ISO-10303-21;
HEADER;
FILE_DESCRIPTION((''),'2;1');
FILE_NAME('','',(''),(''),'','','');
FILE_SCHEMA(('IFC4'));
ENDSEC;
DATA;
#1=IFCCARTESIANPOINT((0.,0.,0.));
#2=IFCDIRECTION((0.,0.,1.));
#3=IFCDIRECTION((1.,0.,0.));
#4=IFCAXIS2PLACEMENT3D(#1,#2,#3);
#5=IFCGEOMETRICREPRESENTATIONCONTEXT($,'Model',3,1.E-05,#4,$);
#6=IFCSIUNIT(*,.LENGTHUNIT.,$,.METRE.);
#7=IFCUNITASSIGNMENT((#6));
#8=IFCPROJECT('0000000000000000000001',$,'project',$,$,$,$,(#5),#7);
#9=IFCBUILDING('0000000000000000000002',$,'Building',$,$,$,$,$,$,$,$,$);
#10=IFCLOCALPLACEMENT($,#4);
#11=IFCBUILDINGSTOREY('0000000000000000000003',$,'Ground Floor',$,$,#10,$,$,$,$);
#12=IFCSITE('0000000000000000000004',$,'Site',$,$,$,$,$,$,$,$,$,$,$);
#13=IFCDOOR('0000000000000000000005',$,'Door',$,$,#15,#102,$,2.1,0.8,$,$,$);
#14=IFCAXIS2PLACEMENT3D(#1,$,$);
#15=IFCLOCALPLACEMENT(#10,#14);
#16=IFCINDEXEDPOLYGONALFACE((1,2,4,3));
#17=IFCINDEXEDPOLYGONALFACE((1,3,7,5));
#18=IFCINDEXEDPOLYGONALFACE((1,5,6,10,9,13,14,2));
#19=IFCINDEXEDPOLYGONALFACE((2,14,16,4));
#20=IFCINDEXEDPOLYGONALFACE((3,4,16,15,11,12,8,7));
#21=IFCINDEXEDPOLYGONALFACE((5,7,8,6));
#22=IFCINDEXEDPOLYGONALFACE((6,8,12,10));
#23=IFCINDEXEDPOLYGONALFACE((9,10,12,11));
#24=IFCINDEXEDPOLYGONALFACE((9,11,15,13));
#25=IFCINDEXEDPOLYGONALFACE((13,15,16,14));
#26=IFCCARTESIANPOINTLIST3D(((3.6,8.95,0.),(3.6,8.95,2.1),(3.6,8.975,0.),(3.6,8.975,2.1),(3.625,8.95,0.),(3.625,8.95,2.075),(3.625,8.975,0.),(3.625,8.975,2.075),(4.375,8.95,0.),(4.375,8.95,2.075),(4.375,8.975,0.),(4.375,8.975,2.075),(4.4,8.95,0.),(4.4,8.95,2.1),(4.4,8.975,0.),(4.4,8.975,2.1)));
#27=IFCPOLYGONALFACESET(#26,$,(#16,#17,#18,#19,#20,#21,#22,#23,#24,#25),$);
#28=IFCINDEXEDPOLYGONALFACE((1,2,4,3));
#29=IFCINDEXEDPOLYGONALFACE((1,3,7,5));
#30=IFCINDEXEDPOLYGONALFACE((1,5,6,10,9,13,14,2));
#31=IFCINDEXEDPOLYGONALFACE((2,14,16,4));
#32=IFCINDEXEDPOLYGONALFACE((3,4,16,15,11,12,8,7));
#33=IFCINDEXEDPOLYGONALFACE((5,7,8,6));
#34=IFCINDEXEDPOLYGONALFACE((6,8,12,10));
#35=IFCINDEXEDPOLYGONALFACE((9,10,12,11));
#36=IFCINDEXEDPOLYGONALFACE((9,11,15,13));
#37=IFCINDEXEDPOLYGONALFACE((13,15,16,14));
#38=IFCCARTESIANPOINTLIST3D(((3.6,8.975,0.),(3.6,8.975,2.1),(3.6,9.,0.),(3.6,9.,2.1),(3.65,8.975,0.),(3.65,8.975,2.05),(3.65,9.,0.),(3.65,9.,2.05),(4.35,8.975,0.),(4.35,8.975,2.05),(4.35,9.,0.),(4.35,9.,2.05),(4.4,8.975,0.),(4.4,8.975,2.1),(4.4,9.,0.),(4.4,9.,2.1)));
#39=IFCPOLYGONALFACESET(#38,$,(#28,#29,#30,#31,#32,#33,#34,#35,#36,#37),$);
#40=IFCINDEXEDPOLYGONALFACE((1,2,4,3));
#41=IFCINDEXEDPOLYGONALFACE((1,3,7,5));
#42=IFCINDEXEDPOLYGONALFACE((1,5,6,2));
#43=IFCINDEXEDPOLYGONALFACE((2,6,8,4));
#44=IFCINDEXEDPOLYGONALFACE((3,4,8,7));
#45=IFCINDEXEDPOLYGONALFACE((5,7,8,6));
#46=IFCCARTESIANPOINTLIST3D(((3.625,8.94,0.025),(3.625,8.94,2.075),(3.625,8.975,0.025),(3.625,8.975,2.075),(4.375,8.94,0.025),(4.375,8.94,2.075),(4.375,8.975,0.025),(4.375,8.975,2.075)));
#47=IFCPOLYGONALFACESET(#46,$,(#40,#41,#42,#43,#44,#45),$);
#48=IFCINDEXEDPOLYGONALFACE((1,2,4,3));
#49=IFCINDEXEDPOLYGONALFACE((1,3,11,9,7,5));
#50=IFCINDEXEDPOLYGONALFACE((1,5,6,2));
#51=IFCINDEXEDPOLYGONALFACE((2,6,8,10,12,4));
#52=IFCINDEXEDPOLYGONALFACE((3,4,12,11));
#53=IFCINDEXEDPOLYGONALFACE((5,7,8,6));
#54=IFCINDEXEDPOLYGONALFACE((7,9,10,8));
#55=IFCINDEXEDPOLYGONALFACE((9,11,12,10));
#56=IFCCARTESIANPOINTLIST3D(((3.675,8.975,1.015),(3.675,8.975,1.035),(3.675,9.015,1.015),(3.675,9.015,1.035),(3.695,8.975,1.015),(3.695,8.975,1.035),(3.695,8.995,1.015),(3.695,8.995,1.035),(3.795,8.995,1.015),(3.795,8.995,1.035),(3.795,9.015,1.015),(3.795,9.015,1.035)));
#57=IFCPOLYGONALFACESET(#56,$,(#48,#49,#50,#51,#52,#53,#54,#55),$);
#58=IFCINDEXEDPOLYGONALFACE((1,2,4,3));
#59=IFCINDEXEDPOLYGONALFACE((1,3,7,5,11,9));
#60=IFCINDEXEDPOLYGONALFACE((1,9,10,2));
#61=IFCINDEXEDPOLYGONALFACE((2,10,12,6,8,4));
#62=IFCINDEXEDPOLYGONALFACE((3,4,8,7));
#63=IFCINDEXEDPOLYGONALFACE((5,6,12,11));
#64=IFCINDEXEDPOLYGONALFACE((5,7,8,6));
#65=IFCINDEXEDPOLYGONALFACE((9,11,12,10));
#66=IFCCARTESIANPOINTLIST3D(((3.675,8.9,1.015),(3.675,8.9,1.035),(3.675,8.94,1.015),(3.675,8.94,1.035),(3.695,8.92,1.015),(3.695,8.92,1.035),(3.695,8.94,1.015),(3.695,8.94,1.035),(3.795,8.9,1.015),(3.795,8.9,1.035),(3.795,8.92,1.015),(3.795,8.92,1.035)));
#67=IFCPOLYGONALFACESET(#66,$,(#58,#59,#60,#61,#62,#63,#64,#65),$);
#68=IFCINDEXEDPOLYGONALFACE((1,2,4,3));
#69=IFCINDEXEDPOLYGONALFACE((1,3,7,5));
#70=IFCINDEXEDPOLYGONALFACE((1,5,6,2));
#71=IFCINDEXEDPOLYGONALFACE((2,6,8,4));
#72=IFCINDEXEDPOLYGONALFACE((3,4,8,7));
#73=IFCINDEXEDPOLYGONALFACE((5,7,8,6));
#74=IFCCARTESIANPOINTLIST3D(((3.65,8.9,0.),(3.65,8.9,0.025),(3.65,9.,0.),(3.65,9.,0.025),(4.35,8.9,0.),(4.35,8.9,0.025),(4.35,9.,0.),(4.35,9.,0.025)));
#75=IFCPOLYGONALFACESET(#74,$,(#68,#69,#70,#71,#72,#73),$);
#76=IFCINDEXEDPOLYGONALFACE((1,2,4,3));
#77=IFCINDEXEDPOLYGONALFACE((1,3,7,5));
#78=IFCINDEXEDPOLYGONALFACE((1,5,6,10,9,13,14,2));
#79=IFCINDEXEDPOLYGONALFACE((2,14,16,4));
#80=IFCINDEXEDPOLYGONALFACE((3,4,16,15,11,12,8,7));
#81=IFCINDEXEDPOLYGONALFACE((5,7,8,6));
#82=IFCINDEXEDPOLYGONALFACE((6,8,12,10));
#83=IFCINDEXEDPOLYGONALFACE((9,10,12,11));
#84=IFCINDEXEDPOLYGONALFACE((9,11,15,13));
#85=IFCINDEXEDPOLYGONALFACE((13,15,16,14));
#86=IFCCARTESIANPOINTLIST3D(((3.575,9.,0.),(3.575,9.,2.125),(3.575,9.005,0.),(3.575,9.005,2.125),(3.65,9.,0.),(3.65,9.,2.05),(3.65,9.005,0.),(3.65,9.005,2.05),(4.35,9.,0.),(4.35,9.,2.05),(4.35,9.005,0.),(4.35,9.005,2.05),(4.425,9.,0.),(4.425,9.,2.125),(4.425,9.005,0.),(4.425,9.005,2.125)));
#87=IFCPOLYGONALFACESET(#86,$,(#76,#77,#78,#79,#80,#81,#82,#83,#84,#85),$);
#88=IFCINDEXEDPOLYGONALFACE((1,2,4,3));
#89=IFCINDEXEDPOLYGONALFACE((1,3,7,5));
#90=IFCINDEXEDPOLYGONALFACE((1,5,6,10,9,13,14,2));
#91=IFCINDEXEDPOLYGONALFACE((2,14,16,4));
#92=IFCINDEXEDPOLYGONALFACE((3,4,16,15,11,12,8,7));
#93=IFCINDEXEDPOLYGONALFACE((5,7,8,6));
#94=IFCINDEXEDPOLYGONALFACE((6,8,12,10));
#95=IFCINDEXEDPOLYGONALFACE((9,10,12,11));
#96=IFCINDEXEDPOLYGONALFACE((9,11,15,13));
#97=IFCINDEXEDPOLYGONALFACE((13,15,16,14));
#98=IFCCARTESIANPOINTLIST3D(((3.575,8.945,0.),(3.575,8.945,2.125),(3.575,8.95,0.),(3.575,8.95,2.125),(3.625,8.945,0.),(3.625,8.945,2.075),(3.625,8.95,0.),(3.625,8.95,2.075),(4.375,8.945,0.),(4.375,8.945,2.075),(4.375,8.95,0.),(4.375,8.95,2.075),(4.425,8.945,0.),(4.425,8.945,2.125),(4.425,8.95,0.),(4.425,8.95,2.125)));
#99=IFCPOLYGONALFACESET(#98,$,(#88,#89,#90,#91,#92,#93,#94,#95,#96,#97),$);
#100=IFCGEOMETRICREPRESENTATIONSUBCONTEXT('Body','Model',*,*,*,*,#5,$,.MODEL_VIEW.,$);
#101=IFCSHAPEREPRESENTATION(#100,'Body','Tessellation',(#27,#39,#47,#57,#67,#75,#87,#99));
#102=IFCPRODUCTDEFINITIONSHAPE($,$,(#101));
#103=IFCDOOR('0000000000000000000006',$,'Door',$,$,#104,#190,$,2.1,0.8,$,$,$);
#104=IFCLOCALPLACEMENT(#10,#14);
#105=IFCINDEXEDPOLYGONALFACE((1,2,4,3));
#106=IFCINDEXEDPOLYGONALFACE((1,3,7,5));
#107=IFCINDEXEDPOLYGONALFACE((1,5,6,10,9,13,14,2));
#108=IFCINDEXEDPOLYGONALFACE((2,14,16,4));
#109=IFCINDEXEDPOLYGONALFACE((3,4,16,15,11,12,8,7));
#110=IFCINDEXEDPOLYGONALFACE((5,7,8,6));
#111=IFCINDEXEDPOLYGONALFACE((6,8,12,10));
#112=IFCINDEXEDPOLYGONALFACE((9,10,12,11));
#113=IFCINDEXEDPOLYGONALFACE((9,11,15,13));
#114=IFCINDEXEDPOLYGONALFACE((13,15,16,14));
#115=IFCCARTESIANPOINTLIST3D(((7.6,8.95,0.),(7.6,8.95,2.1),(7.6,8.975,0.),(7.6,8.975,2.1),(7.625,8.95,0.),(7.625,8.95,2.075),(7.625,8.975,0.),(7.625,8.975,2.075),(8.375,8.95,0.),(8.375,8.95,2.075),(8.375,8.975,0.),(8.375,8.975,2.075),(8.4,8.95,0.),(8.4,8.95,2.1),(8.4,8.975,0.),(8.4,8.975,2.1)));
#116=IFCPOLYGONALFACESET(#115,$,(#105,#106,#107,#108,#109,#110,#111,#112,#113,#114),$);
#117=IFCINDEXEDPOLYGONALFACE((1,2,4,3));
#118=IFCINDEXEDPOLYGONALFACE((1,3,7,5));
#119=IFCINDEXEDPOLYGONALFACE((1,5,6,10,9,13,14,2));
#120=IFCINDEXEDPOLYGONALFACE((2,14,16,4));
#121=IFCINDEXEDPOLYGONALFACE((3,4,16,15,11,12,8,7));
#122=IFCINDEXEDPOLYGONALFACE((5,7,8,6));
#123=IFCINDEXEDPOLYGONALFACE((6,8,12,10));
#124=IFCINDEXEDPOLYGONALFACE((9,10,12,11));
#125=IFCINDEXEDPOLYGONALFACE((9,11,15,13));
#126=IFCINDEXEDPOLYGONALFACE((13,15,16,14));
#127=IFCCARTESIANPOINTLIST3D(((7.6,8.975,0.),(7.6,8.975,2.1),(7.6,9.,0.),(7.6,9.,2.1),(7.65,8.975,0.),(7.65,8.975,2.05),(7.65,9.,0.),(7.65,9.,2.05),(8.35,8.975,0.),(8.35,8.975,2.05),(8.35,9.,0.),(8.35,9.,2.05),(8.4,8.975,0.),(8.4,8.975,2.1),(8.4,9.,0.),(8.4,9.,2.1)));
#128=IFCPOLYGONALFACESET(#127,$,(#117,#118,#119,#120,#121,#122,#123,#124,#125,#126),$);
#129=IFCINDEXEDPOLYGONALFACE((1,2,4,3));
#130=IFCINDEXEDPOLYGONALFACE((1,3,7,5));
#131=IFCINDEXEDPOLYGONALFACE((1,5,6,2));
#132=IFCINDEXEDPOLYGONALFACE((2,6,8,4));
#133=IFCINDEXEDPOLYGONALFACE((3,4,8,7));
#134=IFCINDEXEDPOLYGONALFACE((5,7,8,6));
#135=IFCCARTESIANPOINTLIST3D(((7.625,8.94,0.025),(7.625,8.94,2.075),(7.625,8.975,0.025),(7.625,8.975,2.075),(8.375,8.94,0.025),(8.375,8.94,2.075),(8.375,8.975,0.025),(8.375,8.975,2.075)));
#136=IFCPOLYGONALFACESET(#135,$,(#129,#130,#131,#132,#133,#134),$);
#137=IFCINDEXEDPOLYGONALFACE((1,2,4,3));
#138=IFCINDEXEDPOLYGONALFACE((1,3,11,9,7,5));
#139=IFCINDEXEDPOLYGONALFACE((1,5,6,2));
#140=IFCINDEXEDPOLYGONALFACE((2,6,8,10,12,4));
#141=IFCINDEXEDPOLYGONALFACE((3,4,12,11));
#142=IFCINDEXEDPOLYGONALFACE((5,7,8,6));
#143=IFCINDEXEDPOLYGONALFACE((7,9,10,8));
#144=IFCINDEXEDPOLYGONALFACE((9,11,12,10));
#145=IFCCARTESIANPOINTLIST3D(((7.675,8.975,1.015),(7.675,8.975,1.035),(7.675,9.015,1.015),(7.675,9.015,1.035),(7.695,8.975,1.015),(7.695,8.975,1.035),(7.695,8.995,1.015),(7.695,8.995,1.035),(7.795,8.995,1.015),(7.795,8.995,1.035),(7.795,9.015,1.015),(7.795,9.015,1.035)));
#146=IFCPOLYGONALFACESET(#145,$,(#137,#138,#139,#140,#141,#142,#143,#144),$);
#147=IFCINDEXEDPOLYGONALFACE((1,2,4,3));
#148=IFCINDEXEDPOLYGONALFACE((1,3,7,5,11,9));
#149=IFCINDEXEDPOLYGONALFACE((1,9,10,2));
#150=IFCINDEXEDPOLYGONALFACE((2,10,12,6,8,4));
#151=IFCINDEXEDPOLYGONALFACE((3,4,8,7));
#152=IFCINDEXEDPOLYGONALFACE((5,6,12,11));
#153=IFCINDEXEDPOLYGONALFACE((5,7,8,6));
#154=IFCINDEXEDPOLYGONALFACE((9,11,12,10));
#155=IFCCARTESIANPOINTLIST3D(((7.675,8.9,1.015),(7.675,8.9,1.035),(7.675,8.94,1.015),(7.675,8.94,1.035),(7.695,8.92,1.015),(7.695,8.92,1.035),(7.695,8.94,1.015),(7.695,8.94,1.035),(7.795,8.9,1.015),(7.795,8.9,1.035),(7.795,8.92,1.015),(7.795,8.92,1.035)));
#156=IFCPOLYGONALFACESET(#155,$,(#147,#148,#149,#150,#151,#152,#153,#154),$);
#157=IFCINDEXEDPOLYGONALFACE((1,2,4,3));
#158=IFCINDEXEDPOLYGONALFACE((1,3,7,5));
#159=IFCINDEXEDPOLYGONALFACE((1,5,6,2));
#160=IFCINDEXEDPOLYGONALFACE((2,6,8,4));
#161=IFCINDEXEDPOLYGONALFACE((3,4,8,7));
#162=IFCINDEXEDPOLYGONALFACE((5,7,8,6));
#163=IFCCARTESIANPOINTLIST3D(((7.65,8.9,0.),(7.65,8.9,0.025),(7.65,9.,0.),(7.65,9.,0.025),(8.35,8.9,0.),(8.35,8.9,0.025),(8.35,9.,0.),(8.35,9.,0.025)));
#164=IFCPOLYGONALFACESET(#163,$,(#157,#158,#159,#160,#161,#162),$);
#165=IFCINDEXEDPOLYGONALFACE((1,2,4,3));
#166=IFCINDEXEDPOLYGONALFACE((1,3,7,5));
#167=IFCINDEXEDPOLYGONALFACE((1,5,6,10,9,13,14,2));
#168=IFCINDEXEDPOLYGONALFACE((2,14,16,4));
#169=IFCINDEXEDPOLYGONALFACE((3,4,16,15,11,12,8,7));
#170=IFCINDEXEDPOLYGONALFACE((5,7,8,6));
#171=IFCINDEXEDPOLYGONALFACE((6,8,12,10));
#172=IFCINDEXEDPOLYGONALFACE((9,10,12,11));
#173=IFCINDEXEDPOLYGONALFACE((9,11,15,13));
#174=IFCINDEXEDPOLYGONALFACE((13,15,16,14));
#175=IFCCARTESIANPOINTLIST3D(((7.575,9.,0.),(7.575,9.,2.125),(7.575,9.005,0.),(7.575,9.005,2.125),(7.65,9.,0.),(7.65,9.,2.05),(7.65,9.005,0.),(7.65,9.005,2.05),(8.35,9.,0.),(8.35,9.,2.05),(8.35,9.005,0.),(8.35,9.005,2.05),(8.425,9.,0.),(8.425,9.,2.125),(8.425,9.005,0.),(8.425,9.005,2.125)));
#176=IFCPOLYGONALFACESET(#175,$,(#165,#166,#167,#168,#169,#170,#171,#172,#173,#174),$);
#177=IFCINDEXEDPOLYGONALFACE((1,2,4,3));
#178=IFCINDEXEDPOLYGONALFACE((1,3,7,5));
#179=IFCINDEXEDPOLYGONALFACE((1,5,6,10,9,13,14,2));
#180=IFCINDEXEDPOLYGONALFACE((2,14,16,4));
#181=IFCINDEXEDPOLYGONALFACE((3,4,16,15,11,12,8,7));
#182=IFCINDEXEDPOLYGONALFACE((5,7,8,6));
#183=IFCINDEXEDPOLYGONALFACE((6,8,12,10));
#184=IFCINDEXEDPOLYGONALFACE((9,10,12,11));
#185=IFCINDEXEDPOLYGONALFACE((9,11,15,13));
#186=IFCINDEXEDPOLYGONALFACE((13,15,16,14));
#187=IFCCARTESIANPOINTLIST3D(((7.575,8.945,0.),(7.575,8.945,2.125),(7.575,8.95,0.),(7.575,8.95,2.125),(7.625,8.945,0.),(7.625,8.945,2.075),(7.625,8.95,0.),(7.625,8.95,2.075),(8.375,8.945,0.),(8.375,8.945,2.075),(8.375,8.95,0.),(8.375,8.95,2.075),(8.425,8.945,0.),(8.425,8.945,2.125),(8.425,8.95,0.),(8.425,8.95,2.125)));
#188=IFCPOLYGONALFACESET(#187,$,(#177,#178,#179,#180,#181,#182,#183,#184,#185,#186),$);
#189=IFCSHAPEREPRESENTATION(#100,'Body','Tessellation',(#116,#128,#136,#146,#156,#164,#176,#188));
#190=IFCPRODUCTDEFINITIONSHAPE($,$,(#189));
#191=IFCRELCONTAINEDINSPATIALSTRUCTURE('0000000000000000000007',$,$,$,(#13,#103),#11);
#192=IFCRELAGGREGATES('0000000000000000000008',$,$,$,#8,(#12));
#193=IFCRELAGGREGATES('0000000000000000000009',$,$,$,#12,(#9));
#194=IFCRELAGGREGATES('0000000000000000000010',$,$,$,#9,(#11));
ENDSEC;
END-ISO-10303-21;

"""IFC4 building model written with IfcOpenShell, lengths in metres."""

from ifc_helpers import new_model, si_unit, frame, origin_with_axes, place, context, subcontext, project, spatial, line, indexed_curve, outline, extrude, element, save


model = new_model("IFC4")

# Units and contexts
model_context = context("Model", 3, precision=1e-05, world=origin_with_axes())
body_context = subcontext(model_context, "Body", "Model", "MODEL_VIEW")
ifc_project = project(units=[si_unit("LENGTHUNIT", "METRE")], contexts=[model_context])

# Site, building, storey
site = spatial("IfcSite", under=ifc_project, Name="Site")
building = spatial("IfcBuilding", under=site, Name="Building")
storey_placement = place(None, origin_with_axes())
storey = spatial("IfcBuildingStorey", under=building, at=storey_placement, Name="Ground Floor")

# Doors
door_1_placement = place(storey_placement, frame((4.4, 9.0, 0.0), z_axis=(0.0, 0.0, 1.0), x_axis=(-1.0, 0.0, 0.0)))
element("IfcDoor", 1, at=door_1_placement, inside=storey, Name="Door", OverallHeight=2.1, OverallWidth=0.8, context=body_context, shape_type="SweptSolid", body=[
    extrude(outline(indexed_curve([(0.0, 0.0), (0.0, 2.1), (0.8, 2.1), (0.8, 0.0), (0.775, 0.0), (0.775, 2.075), (0.025, 2.075), (0.025, 0.0)], segments=[line(1, 2, 3, 4, 5, 6, 7, 8, 1)])), frame((0.0, 0.025, 0.0), z_axis=(0.0, -1.0, 0.0), x_axis=(1.0, 0.0, 0.0)), (0.0, 0.0, -1.0), 0.025),
    extrude(outline(indexed_curve([(0.0, 0.0), (0.0, 2.1), (0.8, 2.1), (0.8, 0.0), (0.75, 0.0), (0.75, 2.05), (0.05, 2.05), (0.05, 0.0)], segments=[line(1, 2, 3, 4, 5, 6, 7, 8, 1)])), frame((0.0, 0.0, 0.0), z_axis=(0.0, -1.0, 0.0), x_axis=(1.0, 0.0, 0.0)), (0.0, 0.0, -1.0), 0.025),
    extrude(outline(indexed_curve([(0.0, 0.0), (0.75, 0.0), (0.75, 0.035), (0.0, 0.035)], segments=[line(1, 2, 3, 4, 1)])), frame((0.025, 0.025, 0.025), z_axis=(0.0, 0.0, 1.0), x_axis=(1.0, 0.0, 0.0)), (0.0, 0.0, 1.0), 2.05),
    extrude(outline(indexed_curve([(0.0, 0.0), (0.0, -0.04), (-0.12, -0.04), (-0.12, -0.02), (-0.02, -0.02), (-0.02, 0.0)], segments=[line(1, 2, 3, 4, 5, 6, 1)])), frame((0.725, 0.025, 1.015), z_axis=(0.0, 0.0, 1.0), x_axis=(1.0, 0.0, 0.0)), (0.0, 0.0, 1.0), 0.02),
    extrude(outline(indexed_curve([(0.0, 0.0), (0.0, 0.04), (-0.12, 0.04), (-0.12, 0.02), (-0.02, 0.02), (-0.02, 0.0)], segments=[line(1, 2, 3, 4, 5, 6, 1)])), frame((0.725, 0.06, 1.015), z_axis=(0.0, 0.0, 1.0), x_axis=(1.0, 0.0, 0.0)), (0.0, 0.0, 1.0), 0.02),
    extrude(outline(indexed_curve([(0.0, 0.0), (0.7, 0.0), (0.7, 0.1), (0.0, 0.1)], segments=[line(1, 2, 3, 4, 1)])), frame((0.05, 0.0, 0.0), z_axis=(0.0, 0.0, 1.0), x_axis=(1.0, 0.0, 0.0)), (0.0, 0.0, 1.0), 0.025),
    extrude(outline(indexed_curve([(0.0, 0.0), (0.0, 2.125), (0.85, 2.125), (0.85, 0.0), (0.775, 0.0), (0.775, 2.05), (0.075, 2.05), (0.075, 0.0)], segments=[line(1, 2, 3, 4, 5, 6, 7, 8, 1)])), frame((-0.025, -0.005, 0.0), z_axis=(0.0, -1.0, 0.0), x_axis=(1.0, 0.0, 0.0)), (0.0, 0.0, -1.0), 0.005),
    extrude(outline(indexed_curve([(0.0, 0.0), (0.0, 2.125), (0.85, 2.125), (0.85, 0.0), (0.8, 0.0), (0.8, 2.075), (0.05, 2.075), (0.05, 0.0)], segments=[line(1, 2, 3, 4, 5, 6, 7, 8, 1)])), frame((-0.025, 0.05, 0.0), z_axis=(0.0, -1.0, 0.0), x_axis=(1.0, 0.0, 0.0)), (0.0, 0.0, -1.0), 0.005),
])
door_2_placement = place(storey_placement, frame((8.4, 9.0, 0.0), z_axis=(0.0, 0.0, 1.0), x_axis=(-1.0, 0.0, 0.0)))
element("IfcDoor", 2, at=door_2_placement, inside=storey, Name="Door", OverallHeight=2.1, OverallWidth=0.8, context=body_context, shape_type="SweptSolid", body=[
    extrude(outline(indexed_curve([(0.0, 0.0), (0.0, 2.1), (0.8, 2.1), (0.8, 0.0), (0.775, 0.0), (0.775, 2.075), (0.025, 2.075), (0.025, 0.0)], segments=[line(1, 2, 3, 4, 5, 6, 7, 8, 1)])), frame((0.0, 0.025, 0.0), z_axis=(0.0, -1.0, 0.0), x_axis=(1.0, 0.0, 0.0)), (0.0, 0.0, -1.0), 0.025),
    extrude(outline(indexed_curve([(0.0, 0.0), (0.0, 2.1), (0.8, 2.1), (0.8, 0.0), (0.75, 0.0), (0.75, 2.05), (0.05, 2.05), (0.05, 0.0)], segments=[line(1, 2, 3, 4, 5, 6, 7, 8, 1)])), frame((0.0, 0.0, 0.0), z_axis=(0.0, -1.0, 0.0), x_axis=(1.0, 0.0, 0.0)), (0.0, 0.0, -1.0), 0.025),
    extrude(outline(indexed_curve([(0.0, 0.0), (0.75, 0.0), (0.75, 0.035), (0.0, 0.035)], segments=[line(1, 2, 3, 4, 1)])), frame((0.025, 0.025, 0.025), z_axis=(0.0, 0.0, 1.0), x_axis=(1.0, 0.0, 0.0)), (0.0, 0.0, 1.0), 2.05),
    extrude(outline(indexed_curve([(0.0, 0.0), (0.0, -0.04), (-0.12, -0.04), (-0.12, -0.02), (-0.02, -0.02), (-0.02, 0.0)], segments=[line(1, 2, 3, 4, 5, 6, 1)])), frame((0.725, 0.025, 1.015), z_axis=(0.0, 0.0, 1.0), x_axis=(1.0, 0.0, 0.0)), (0.0, 0.0, 1.0), 0.02),
    extrude(outline(indexed_curve([(0.0, 0.0), (0.0, 0.04), (-0.12, 0.04), (-0.12, 0.02), (-0.02, 0.02), (-0.02, 0.0)], segments=[line(1, 2, 3, 4, 5, 6, 1)])), frame((0.725, 0.06, 1.015), z_axis=(0.0, 0.0, 1.0), x_axis=(1.0, 0.0, 0.0)), (0.0, 0.0, 1.0), 0.02),
    extrude(outline(indexed_curve([(0.0, 0.0), (0.7, 0.0), (0.7, 0.1), (0.0, 0.1)], segments=[line(1, 2, 3, 4, 1)])), frame((0.05, 0.0, 0.0), z_axis=(0.0, 0.0, 1.0), x_axis=(1.0, 0.0, 0.0)), (0.0, 0.0, 1.0), 0.025),
    extrude(outline(indexed_curve([(0.0, 0.0), (0.0, 2.125), (0.85, 2.125), (0.85, 0.0), (0.775, 0.0), (0.775, 2.05), (0.075, 2.05), (0.075, 0.0)], segments=[line(1, 2, 3, 4, 5, 6, 7, 8, 1)])), frame((-0.025, -0.005, 0.0), z_axis=(0.0, -1.0, 0.0), x_axis=(1.0, 0.0, 0.0)), (0.0, 0.0, -1.0), 0.005),
    extrude(outline(indexed_curve([(0.0, 0.0), (0.0, 2.125), (0.85, 2.125), (0.85, 0.0), (0.8, 0.0), (0.8, 2.075), (0.05, 2.075), (0.05, 0.0)], segments=[line(1, 2, 3, 4, 5, 6, 7, 8, 1)])), frame((-0.025, 0.05, 0.0), z_axis=(0.0, -1.0, 0.0), x_axis=(1.0, 0.0, 0.0)), (0.0, 0.0, -1.0), 0.005),
])

save(model, "model.ifc")
